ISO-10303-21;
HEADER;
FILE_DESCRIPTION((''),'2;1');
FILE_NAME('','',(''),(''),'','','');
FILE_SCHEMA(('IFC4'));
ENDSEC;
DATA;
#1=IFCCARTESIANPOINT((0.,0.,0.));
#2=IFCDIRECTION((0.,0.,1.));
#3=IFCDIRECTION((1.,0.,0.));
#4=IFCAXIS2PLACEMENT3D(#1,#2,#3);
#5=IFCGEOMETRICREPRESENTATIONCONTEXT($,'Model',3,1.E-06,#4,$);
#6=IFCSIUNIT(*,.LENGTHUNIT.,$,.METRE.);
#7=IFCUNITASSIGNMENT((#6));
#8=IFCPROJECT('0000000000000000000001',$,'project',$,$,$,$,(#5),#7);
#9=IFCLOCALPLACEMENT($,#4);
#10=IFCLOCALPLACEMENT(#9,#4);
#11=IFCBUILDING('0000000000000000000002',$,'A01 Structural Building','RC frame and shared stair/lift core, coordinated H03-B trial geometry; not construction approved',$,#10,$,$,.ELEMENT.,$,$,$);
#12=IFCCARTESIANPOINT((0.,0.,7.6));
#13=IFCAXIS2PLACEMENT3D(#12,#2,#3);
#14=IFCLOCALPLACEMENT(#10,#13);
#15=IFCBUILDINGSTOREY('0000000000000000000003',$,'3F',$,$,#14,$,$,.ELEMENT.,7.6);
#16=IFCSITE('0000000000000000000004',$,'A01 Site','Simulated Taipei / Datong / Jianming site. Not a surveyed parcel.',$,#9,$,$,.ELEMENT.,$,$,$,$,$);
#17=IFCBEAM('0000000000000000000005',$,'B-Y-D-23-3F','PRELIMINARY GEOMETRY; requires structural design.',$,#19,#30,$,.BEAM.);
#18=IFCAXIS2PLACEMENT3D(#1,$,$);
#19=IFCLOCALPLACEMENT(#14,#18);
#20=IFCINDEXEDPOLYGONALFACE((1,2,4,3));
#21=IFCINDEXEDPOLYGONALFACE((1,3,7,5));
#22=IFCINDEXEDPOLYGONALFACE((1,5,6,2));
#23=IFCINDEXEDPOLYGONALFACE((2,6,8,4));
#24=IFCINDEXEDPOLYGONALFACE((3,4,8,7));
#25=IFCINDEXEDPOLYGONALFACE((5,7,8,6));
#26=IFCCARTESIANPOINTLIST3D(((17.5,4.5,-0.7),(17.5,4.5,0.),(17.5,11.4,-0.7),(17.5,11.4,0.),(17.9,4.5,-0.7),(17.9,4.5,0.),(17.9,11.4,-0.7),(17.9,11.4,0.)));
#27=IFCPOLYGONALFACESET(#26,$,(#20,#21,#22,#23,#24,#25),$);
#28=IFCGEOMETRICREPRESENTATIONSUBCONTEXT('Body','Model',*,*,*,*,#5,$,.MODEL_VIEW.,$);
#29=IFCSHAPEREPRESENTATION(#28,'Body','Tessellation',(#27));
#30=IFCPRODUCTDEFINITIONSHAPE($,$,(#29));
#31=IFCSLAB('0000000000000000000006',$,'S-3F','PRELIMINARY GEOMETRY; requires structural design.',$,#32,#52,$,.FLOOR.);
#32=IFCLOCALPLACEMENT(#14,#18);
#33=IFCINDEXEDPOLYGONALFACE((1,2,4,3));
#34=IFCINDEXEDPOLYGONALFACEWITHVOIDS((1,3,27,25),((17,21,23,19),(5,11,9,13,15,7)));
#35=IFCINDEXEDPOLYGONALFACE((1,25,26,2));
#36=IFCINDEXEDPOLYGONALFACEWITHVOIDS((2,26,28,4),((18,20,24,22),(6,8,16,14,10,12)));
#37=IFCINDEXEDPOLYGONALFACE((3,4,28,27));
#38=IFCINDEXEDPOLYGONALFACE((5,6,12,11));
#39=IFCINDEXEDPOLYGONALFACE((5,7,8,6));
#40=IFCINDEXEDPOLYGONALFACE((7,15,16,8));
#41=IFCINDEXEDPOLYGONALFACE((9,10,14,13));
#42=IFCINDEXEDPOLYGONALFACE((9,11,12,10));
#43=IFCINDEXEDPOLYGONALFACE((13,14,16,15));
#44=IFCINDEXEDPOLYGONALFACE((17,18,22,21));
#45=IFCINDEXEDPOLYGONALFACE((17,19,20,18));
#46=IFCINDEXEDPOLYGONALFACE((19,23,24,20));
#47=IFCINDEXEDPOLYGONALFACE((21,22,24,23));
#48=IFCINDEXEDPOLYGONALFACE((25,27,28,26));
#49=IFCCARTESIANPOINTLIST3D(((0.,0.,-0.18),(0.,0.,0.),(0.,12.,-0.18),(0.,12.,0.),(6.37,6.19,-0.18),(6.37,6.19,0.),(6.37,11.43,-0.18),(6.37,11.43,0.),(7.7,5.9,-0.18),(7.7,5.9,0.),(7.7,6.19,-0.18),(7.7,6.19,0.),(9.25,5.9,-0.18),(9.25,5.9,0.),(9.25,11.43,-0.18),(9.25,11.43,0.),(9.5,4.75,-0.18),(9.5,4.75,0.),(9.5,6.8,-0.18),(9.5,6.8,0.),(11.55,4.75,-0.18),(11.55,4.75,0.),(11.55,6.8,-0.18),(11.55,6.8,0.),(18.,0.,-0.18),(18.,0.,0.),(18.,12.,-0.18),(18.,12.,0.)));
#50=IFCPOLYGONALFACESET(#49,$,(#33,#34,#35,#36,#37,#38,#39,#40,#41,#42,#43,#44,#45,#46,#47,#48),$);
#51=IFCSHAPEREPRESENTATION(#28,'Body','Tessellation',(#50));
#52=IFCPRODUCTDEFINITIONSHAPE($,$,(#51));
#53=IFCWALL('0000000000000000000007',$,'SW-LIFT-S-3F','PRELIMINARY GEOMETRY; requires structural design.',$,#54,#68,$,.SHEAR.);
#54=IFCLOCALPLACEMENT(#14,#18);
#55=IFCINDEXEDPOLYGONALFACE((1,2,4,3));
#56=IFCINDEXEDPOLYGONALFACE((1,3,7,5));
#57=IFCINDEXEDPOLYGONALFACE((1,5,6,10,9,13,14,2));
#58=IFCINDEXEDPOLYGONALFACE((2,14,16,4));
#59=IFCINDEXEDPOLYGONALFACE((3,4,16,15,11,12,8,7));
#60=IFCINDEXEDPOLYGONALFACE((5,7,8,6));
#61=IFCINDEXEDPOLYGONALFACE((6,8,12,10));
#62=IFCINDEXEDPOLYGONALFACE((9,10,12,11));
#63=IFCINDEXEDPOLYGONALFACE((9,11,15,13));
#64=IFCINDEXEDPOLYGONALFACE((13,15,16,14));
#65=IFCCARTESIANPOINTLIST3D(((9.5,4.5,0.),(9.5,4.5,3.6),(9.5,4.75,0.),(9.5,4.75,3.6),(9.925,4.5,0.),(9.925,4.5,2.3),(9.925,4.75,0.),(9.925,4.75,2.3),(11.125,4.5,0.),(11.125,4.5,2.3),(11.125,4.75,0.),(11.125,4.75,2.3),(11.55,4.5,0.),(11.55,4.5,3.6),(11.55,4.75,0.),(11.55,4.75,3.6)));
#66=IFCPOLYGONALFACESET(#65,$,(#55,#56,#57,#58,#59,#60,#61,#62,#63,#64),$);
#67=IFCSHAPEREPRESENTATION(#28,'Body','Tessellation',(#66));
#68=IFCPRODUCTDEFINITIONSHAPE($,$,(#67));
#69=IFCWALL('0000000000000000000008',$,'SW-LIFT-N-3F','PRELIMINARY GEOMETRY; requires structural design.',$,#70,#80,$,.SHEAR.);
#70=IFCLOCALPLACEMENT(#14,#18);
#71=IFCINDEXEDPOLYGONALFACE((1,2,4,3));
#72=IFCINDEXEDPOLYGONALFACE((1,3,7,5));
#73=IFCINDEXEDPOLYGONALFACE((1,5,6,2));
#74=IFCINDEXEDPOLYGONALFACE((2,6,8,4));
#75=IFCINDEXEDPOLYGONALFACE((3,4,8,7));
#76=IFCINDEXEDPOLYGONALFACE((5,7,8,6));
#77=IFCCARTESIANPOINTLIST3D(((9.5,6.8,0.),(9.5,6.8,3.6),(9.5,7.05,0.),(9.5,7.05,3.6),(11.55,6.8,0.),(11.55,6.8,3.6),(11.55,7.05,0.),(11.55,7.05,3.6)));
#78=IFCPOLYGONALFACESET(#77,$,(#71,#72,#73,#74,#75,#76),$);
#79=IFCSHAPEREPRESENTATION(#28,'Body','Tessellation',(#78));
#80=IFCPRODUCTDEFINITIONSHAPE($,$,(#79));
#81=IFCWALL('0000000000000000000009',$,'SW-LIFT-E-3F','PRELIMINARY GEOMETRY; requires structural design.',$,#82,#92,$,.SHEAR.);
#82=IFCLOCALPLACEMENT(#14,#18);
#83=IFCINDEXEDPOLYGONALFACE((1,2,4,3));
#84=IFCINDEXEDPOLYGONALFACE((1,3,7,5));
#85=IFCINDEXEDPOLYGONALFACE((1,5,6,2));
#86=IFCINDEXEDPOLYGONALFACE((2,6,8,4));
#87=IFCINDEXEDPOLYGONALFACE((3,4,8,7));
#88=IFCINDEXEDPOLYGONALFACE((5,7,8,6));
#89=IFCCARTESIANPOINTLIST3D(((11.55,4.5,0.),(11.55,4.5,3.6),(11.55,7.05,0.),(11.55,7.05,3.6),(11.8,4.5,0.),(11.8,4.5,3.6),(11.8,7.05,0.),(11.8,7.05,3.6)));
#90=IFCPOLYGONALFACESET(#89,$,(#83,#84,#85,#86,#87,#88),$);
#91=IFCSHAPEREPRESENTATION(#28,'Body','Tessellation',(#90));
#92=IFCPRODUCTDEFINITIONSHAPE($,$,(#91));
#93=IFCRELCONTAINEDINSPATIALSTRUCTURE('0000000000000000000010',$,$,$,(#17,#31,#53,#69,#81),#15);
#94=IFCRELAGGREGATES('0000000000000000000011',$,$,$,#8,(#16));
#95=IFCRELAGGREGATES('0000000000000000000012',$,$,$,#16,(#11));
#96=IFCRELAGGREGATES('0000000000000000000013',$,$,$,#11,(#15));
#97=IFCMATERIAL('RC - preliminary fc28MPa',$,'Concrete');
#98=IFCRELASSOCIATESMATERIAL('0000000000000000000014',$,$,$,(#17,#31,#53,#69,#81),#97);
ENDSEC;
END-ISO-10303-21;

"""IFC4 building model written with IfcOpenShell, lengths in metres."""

from ifc_helpers import new_model, si_unit, frame, origin_with_axes, place, context, subcontext, project, spatial, polyline, rectangle, outline, extrude, material, element, save


model = new_model("IFC4")

# Units and contexts
model_context = context("Model", 3, precision=1e-06, world=origin_with_axes())
body_context = subcontext(model_context, "Body", "Model", "MODEL_VIEW")
ifc_project = project(units=[si_unit("LENGTHUNIT", "METRE")], contexts=[model_context])

# Site, building, storey
site_placement = place(None, origin_with_axes())
site = spatial("IfcSite", under=ifc_project, at=site_placement, Name="A01 Site", Description="Simulated Taipei / Datong / Jianming site. Not a surveyed parcel.", CompositionType="ELEMENT")
building_placement = place(site_placement, origin_with_axes())
building = spatial("IfcBuilding", under=site, at=building_placement, Name="A01 Structural Building", Description="RC frame and shared stair/lift core, coordinated H03-B trial geometry; not construction approved", CompositionType="ELEMENT")
storey_placement = place(building_placement, frame((0.0, 0.0, 7.6), z_axis=(0.0, 0.0, 1.0), x_axis=(1.0, 0.0, 0.0)))
storey = spatial("IfcBuildingStorey", under=building, at=storey_placement, Name="3F", CompositionType="ELEMENT", Elevation=7.6)

# Shared definitions
ifc_material = material(Name="RC - preliminary fc28MPa", Category="Concrete")

# Beam
beam_1_placement = place(storey_placement, frame((17.7, 7.95, -0.7), z_axis=(0.0, 0.0, 1.0), x_axis=(1.0, 0.0, 0.0)))
element("IfcBeam", 1, at=beam_1_placement, inside=storey, material=ifc_material, Name="B-Y-D-23-3F", Description="PRELIMINARY GEOMETRY; requires structural design.", PredefinedType="BEAM", context=body_context, shape_type="SweptSolid", body=[
    extrude(rectangle(XDim=0.4, YDim=6.9), origin_with_axes(), (0.0, 0.0, 1.0), 0.7),
])

# Slab, openings
slab_placement = place(storey_placement, frame((9.0, 6.0, -0.18), z_axis=(0.0, 0.0, 1.0), x_axis=(1.0, 0.0, 0.0)))
slab = element("IfcSlab", 2, at=slab_placement, inside=storey, material=ifc_material, Name="S-3F", Description="PRELIMINARY GEOMETRY; requires structural design.", PredefinedType="FLOOR", context=body_context, shape_type="SweptSolid", body=[
    extrude(rectangle(XDim=18.0, YDim=12.0), origin_with_axes(), (0.0, 0.0, 1.0), 0.18),
])
opening_1_placement = place(storey_placement, frame((10.525, 5.775, -0.23), z_axis=(0.0, 0.0, 1.0), x_axis=(1.0, 0.0, 0.0)))
element("IfcOpeningElement", 3, at=opening_1_placement, cuts=slab, PredefinedType="OPENING", context=body_context, shape_type="SweptSolid", body=[
    extrude(rectangle(XDim=2.05, YDim=2.05), origin_with_axes(), (0.0, 0.0, 1.0), 0.28),
])
opening_2_placement = place(None, origin_with_axes())
element("IfcOpeningElement", 4, at=opening_2_placement, cuts=slab, PredefinedType="OPENING", context=body_context, shape_type="SweptSolid", body=[
    extrude(outline(polyline([(6.37, 6.19), (6.37, 11.43), (9.25, 11.43), (9.25, 5.9), (7.7, 5.9), (7.7, 6.19), (6.37, 6.19)])), frame((0.0, 0.0, 7.37), z_axis=(0.0, 0.0, 1.0), x_axis=(1.0, 0.0, 0.0)), (0.0, 0.0, 1.0), 0.28),
])

# Wall, opening
wall_1_placement = place(storey_placement, frame((10.525, 4.625, 0.0), z_axis=(0.0, 0.0, 1.0), x_axis=(1.0, 0.0, 0.0)))
wall_1 = element("IfcWall", 5, at=wall_1_placement, inside=storey, material=ifc_material, Name="SW-LIFT-S-3F", Description="PRELIMINARY GEOMETRY; requires structural design.", PredefinedType="SHEAR", context=body_context, shape_type="SweptSolid", body=[
    extrude(rectangle(XDim=2.05, YDim=0.25), origin_with_axes(), (0.0, 0.0, 1.0), 3.6),
])
opening_3_placement = place(storey_placement, frame((10.525, 4.625, 0.0), z_axis=(0.0, 0.0, 1.0), x_axis=(1.0, 0.0, 0.0)))
element("IfcOpeningElement", 6, at=opening_3_placement, cuts=wall_1, PredefinedType="OPENING", context=body_context, shape_type="SweptSolid", body=[
    extrude(rectangle(XDim=1.2, YDim=0.45), origin_with_axes(), (0.0, 0.0, 1.0), 2.3),
])

# Walls
wall_2_placement = place(storey_placement, frame((10.525, 6.925, 0.0), z_axis=(0.0, 0.0, 1.0), x_axis=(1.0, 0.0, 0.0)))
element("IfcWall", 7, at=wall_2_placement, inside=storey, material=ifc_material, Name="SW-LIFT-N-3F", Description="PRELIMINARY GEOMETRY; requires structural design.", PredefinedType="SHEAR", context=body_context, shape_type="SweptSolid", body=[
    extrude(rectangle(XDim=2.05, YDim=0.25), origin_with_axes(), (0.0, 0.0, 1.0), 3.6),
])
wall_3_placement = place(storey_placement, frame((11.675, 5.775, 0.0), z_axis=(0.0, 0.0, 1.0), x_axis=(1.0, 0.0, 0.0)))
element("IfcWall", 8, at=wall_3_placement, inside=storey, material=ifc_material, Name="SW-LIFT-E-3F", Description="PRELIMINARY GEOMETRY; requires structural design.", PredefinedType="SHEAR", context=body_context, shape_type="SweptSolid", body=[
    extrude(rectangle(XDim=0.25, YDim=2.55), origin_with_axes(), (0.0, 0.0, 1.0), 3.6),
])

save(model, "model.ifc")
